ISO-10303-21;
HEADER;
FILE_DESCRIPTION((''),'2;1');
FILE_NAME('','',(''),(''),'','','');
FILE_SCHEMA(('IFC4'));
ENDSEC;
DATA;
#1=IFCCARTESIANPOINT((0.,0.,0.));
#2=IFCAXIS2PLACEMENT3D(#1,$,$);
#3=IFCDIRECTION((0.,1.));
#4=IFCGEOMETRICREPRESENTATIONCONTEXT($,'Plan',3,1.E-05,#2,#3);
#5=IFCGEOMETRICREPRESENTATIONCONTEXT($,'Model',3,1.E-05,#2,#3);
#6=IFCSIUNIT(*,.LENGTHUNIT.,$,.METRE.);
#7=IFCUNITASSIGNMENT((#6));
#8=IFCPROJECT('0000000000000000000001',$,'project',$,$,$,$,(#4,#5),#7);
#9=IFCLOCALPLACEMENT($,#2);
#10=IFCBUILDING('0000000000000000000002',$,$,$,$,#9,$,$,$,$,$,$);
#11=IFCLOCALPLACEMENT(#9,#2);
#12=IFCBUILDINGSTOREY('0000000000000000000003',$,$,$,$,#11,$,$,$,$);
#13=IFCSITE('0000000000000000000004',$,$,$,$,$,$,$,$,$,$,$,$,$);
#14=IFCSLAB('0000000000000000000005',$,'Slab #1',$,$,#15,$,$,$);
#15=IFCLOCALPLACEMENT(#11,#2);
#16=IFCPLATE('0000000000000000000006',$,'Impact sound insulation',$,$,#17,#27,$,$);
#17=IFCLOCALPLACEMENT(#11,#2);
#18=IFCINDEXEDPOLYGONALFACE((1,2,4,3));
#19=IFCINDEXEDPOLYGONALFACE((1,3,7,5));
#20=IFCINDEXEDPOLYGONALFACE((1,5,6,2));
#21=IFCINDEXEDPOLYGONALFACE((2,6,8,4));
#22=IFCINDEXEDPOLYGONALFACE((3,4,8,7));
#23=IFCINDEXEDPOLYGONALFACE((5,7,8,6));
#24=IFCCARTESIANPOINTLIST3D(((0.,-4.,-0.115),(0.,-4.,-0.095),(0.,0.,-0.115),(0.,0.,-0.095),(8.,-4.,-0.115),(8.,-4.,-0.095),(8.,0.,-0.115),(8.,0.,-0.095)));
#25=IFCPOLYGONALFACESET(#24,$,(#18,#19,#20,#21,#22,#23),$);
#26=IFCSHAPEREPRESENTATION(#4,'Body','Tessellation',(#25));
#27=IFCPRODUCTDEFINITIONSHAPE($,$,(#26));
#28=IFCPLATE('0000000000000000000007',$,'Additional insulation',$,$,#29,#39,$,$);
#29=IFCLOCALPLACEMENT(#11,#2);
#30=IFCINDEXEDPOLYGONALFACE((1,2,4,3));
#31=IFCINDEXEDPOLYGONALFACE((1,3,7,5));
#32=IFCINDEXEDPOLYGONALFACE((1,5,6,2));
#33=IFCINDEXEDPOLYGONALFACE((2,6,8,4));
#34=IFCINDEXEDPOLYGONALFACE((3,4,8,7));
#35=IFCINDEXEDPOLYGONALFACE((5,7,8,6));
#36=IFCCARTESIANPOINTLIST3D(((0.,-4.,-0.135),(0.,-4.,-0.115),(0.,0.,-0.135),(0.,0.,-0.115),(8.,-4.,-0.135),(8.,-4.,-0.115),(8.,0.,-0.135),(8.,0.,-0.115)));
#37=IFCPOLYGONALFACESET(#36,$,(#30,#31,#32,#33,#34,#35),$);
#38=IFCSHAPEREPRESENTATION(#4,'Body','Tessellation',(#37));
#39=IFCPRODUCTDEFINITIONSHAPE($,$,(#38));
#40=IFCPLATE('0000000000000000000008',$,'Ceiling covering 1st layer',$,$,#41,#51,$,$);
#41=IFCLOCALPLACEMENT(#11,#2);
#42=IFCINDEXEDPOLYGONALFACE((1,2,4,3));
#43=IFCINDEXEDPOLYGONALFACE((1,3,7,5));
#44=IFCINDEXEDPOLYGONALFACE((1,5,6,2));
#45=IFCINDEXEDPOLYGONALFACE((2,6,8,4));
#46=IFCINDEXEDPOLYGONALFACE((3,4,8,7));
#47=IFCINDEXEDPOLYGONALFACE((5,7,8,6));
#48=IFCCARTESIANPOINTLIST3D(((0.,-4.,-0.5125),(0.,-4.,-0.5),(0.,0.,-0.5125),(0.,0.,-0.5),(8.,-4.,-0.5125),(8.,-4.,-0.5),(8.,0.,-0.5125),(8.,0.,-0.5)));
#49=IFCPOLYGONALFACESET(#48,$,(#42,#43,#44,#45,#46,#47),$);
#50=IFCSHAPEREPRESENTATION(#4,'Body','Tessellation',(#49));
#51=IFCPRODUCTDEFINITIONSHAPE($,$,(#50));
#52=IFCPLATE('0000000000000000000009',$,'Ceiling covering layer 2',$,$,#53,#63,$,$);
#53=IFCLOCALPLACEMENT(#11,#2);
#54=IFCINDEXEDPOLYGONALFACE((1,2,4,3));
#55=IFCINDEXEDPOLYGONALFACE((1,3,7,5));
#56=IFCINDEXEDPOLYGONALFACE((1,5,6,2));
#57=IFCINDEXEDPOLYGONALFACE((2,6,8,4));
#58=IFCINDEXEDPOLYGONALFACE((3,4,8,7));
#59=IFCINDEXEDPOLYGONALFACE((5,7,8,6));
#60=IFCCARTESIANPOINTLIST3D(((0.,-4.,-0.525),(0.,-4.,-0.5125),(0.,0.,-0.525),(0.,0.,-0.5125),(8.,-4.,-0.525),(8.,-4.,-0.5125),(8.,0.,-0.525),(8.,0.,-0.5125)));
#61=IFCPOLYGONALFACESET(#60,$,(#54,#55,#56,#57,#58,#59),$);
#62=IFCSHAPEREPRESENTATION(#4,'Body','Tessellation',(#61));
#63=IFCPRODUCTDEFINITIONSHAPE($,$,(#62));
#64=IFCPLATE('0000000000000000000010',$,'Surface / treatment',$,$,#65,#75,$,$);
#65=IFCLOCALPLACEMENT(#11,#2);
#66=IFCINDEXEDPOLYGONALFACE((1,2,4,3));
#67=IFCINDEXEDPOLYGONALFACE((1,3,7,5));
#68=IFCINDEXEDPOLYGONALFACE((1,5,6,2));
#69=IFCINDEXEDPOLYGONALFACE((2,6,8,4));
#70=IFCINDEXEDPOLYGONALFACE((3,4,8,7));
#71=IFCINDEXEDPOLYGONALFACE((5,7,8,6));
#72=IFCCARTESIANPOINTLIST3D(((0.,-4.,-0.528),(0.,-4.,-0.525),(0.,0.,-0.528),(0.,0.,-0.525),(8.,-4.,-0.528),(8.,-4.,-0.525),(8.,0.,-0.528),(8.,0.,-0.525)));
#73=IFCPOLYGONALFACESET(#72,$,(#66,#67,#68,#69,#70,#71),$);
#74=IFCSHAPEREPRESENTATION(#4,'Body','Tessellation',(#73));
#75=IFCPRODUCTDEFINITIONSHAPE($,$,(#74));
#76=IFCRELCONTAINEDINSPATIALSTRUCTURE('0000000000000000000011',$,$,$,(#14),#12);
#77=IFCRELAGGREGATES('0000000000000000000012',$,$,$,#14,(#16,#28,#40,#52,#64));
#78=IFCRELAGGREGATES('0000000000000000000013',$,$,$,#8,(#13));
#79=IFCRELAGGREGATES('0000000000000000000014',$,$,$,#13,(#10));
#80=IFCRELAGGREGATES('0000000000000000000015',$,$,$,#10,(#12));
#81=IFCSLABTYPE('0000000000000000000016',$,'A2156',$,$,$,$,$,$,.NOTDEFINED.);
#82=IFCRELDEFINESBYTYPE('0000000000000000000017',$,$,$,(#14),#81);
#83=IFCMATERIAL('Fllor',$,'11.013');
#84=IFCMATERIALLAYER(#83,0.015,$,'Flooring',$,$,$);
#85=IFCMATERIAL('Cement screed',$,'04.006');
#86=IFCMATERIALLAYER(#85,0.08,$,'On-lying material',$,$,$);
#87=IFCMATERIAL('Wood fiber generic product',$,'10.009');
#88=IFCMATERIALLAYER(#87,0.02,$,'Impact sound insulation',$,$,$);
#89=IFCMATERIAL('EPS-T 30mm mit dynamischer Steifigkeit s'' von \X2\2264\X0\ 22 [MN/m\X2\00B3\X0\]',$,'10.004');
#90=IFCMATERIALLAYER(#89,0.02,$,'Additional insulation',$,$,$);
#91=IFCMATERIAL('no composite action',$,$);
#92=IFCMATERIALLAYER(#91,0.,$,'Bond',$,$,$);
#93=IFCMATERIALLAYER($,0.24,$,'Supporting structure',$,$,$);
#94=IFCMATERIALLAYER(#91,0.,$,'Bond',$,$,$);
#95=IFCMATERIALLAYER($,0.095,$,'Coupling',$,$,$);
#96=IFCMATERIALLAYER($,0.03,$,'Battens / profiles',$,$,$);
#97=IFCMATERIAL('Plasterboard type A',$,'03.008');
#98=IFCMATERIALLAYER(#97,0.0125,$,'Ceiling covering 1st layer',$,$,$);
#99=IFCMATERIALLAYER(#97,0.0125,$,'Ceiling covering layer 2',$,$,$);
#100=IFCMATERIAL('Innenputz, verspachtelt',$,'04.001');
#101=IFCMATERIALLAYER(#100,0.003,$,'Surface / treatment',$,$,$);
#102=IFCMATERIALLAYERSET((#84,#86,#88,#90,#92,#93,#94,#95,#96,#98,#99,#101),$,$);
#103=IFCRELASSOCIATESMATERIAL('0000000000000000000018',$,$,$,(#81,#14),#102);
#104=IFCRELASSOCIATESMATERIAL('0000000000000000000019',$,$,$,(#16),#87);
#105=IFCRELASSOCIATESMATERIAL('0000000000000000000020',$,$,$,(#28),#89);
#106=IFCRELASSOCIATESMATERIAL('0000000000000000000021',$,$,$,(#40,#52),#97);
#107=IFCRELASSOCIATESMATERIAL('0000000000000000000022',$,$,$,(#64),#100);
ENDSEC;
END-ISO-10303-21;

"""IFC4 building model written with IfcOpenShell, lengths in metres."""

from ifc_helpers import new_model, si_unit, direction, frame, frame_2d, origin, place, context, project, spatial, rectangle, extrude, material, layer, layer_set, type_object, element, aggregate, save


model = new_model("IFC4")

# Units and contexts
plan_context = context("Plan", 3, precision=1e-05, world=origin(), true_north=direction((0.0, 1.0)))
model_context = context("Model", 3, precision=1e-05, world=origin(), true_north=direction((0.0, 1.0)))
ifc_project = project(units=[si_unit("LENGTHUNIT", "METRE")], contexts=[plan_context, model_context])

# Site, building, storey
site = spatial("IfcSite", under=ifc_project)
building_placement = place(None, origin())
building = spatial("IfcBuilding", under=site, at=building_placement)
storey_placement = place(building_placement, origin())
storey = spatial("IfcBuildingStorey", under=building, at=storey_placement)

# Slab, plates
ifc_material_1 = material(Name="Fllor", Category="11.013")
ifc_layer_1 = layer(ifc_material_1, 0.015, Name="Flooring")
ifc_material_2 = material(Name="Cement screed", Category="04.006")
ifc_layer_2 = layer(ifc_material_2, 0.08, Name="On-lying material")
ifc_material_3 = material(Name="Wood fiber generic product", Category="10.009")
ifc_layer_3 = layer(ifc_material_3, 0.02, Name="Impact sound insulation")
ifc_material_4 = material(Name="EPS-T 30mm mit dynamischer Steifigkeit s' von ≤ 22 [MN/m³]", Category="10.004")
ifc_layer_4 = layer(ifc_material_4, 0.02, Name="Additional insulation")
ifc_material_5 = material(Name="no composite action")
ifc_layer_5 = layer(ifc_material_5, 0.0, Name="Bond")
ifc_layer_6 = layer(None, 0.24, Name="Supporting structure")
ifc_layer_7 = layer(ifc_material_5, 0.0, Name="Bond")
ifc_layer_8 = layer(None, 0.095, Name="Coupling")
ifc_layer_9 = layer(None, 0.03, Name="Battens / profiles")
ifc_material_6 = material(Name="Plasterboard type A", Category="03.008")
ifc_layer_10 = layer(ifc_material_6, 0.0125, Name="Ceiling covering 1st layer")
ifc_layer_11 = layer(ifc_material_6, 0.0125, Name="Ceiling covering layer 2")
ifc_material_7 = material(Name="Innenputz, verspachtelt", Category="04.001")
ifc_layer_12 = layer(ifc_material_7, 0.003, Name="Surface / treatment")
ifc_layer_set = layer_set([ifc_layer_1, ifc_layer_2, ifc_layer_3, ifc_layer_4, ifc_layer_5, ifc_layer_6, ifc_layer_7, ifc_layer_8, ifc_layer_9, ifc_layer_10, ifc_layer_11, ifc_layer_12])
slab_type = type_object("IfcSlabType", Name="A2156", PredefinedType="NOTDEFINED", material=ifc_layer_set)
slab_placement = place(None, frame((0.0, 0.0, 0.0), z_axis=(0.0, 0.0, -1.0), x_axis=(1.0, 0.0, 0.0)))
slab = element("IfcSlab", 1, at=slab_placement, inside=storey, type_object=slab_type, material=ifc_layer_set, Name="Slab #1")
plate_1_placement = place(slab_placement, origin())
plate_1 = element("IfcPlate", 2, at=plate_1_placement, material=ifc_material_3, Name="Impact sound insulation", context=plan_context, shape_type="SweptSolid", body=[
    extrude(rectangle(XDim=8.0, YDim=4.0, at=frame_2d((4.0, 2.0), x_axis=(1.0, 0.0))), frame((0.0, 0.0, 0.095), z_axis=(0.0, 0.0, 1.0), x_axis=(1.0, 0.0, 0.0)), (0.0, 0.0, 1.0), 0.02),
])
plate_2_placement = place(slab_placement, origin())
plate_2 = element("IfcPlate", 3, at=plate_2_placement, material=ifc_material_4, Name="Additional insulation", context=plan_context, shape_type="SweptSolid", body=[
    extrude(rectangle(XDim=8.0, YDim=4.0, at=frame_2d((4.0, 2.0), x_axis=(1.0, 0.0))), frame((0.0, 0.0, 0.115), z_axis=(0.0, 0.0, 1.0), x_axis=(1.0, 0.0, 0.0)), (0.0, 0.0, 1.0), 0.02),
])
plate_3_placement = place(slab_placement, origin())
plate_3 = element("IfcPlate", 4, at=plate_3_placement, material=ifc_material_6, Name="Ceiling covering 1st layer", context=plan_context, shape_type="SweptSolid", body=[
    extrude(rectangle(XDim=8.0, YDim=4.0, at=frame_2d((4.0, 2.0), x_axis=(1.0, 0.0))), frame((0.0, 0.0, 0.5), z_axis=(0.0, 0.0, 1.0), x_axis=(1.0, 0.0, 0.0)), (0.0, 0.0, 1.0), 0.0125),
])
plate_4_placement = place(slab_placement, origin())
plate_4 = element("IfcPlate", 5, at=plate_4_placement, material=ifc_material_6, Name="Ceiling covering layer 2", context=plan_context, shape_type="SweptSolid", body=[
    extrude(rectangle(XDim=8.0, YDim=4.0, at=frame_2d((4.0, 2.0), x_axis=(1.0, 0.0))), frame((0.0, 0.0, 0.5125), z_axis=(0.0, 0.0, 1.0), x_axis=(1.0, 0.0, 0.0)), (0.0, 0.0, 1.0), 0.0125),
])
plate_5_placement = place(slab_placement, origin())
plate_5 = element("IfcPlate", 6, at=plate_5_placement, material=ifc_material_7, Name="Surface / treatment", context=plan_context, shape_type="SweptSolid", body=[
    extrude(rectangle(XDim=8.0, YDim=4.0, at=frame_2d((4.0, 2.0), x_axis=(1.0, 0.0))), frame((0.0, 0.0, 0.525), z_axis=(0.0, 0.0, 1.0), x_axis=(1.0, 0.0, 0.0)), (0.0, 0.0, 1.0), 0.003),
])
aggregate(slab, [plate_1, plate_2, plate_3, plate_4, plate_5])

save(model, "model.ifc")
